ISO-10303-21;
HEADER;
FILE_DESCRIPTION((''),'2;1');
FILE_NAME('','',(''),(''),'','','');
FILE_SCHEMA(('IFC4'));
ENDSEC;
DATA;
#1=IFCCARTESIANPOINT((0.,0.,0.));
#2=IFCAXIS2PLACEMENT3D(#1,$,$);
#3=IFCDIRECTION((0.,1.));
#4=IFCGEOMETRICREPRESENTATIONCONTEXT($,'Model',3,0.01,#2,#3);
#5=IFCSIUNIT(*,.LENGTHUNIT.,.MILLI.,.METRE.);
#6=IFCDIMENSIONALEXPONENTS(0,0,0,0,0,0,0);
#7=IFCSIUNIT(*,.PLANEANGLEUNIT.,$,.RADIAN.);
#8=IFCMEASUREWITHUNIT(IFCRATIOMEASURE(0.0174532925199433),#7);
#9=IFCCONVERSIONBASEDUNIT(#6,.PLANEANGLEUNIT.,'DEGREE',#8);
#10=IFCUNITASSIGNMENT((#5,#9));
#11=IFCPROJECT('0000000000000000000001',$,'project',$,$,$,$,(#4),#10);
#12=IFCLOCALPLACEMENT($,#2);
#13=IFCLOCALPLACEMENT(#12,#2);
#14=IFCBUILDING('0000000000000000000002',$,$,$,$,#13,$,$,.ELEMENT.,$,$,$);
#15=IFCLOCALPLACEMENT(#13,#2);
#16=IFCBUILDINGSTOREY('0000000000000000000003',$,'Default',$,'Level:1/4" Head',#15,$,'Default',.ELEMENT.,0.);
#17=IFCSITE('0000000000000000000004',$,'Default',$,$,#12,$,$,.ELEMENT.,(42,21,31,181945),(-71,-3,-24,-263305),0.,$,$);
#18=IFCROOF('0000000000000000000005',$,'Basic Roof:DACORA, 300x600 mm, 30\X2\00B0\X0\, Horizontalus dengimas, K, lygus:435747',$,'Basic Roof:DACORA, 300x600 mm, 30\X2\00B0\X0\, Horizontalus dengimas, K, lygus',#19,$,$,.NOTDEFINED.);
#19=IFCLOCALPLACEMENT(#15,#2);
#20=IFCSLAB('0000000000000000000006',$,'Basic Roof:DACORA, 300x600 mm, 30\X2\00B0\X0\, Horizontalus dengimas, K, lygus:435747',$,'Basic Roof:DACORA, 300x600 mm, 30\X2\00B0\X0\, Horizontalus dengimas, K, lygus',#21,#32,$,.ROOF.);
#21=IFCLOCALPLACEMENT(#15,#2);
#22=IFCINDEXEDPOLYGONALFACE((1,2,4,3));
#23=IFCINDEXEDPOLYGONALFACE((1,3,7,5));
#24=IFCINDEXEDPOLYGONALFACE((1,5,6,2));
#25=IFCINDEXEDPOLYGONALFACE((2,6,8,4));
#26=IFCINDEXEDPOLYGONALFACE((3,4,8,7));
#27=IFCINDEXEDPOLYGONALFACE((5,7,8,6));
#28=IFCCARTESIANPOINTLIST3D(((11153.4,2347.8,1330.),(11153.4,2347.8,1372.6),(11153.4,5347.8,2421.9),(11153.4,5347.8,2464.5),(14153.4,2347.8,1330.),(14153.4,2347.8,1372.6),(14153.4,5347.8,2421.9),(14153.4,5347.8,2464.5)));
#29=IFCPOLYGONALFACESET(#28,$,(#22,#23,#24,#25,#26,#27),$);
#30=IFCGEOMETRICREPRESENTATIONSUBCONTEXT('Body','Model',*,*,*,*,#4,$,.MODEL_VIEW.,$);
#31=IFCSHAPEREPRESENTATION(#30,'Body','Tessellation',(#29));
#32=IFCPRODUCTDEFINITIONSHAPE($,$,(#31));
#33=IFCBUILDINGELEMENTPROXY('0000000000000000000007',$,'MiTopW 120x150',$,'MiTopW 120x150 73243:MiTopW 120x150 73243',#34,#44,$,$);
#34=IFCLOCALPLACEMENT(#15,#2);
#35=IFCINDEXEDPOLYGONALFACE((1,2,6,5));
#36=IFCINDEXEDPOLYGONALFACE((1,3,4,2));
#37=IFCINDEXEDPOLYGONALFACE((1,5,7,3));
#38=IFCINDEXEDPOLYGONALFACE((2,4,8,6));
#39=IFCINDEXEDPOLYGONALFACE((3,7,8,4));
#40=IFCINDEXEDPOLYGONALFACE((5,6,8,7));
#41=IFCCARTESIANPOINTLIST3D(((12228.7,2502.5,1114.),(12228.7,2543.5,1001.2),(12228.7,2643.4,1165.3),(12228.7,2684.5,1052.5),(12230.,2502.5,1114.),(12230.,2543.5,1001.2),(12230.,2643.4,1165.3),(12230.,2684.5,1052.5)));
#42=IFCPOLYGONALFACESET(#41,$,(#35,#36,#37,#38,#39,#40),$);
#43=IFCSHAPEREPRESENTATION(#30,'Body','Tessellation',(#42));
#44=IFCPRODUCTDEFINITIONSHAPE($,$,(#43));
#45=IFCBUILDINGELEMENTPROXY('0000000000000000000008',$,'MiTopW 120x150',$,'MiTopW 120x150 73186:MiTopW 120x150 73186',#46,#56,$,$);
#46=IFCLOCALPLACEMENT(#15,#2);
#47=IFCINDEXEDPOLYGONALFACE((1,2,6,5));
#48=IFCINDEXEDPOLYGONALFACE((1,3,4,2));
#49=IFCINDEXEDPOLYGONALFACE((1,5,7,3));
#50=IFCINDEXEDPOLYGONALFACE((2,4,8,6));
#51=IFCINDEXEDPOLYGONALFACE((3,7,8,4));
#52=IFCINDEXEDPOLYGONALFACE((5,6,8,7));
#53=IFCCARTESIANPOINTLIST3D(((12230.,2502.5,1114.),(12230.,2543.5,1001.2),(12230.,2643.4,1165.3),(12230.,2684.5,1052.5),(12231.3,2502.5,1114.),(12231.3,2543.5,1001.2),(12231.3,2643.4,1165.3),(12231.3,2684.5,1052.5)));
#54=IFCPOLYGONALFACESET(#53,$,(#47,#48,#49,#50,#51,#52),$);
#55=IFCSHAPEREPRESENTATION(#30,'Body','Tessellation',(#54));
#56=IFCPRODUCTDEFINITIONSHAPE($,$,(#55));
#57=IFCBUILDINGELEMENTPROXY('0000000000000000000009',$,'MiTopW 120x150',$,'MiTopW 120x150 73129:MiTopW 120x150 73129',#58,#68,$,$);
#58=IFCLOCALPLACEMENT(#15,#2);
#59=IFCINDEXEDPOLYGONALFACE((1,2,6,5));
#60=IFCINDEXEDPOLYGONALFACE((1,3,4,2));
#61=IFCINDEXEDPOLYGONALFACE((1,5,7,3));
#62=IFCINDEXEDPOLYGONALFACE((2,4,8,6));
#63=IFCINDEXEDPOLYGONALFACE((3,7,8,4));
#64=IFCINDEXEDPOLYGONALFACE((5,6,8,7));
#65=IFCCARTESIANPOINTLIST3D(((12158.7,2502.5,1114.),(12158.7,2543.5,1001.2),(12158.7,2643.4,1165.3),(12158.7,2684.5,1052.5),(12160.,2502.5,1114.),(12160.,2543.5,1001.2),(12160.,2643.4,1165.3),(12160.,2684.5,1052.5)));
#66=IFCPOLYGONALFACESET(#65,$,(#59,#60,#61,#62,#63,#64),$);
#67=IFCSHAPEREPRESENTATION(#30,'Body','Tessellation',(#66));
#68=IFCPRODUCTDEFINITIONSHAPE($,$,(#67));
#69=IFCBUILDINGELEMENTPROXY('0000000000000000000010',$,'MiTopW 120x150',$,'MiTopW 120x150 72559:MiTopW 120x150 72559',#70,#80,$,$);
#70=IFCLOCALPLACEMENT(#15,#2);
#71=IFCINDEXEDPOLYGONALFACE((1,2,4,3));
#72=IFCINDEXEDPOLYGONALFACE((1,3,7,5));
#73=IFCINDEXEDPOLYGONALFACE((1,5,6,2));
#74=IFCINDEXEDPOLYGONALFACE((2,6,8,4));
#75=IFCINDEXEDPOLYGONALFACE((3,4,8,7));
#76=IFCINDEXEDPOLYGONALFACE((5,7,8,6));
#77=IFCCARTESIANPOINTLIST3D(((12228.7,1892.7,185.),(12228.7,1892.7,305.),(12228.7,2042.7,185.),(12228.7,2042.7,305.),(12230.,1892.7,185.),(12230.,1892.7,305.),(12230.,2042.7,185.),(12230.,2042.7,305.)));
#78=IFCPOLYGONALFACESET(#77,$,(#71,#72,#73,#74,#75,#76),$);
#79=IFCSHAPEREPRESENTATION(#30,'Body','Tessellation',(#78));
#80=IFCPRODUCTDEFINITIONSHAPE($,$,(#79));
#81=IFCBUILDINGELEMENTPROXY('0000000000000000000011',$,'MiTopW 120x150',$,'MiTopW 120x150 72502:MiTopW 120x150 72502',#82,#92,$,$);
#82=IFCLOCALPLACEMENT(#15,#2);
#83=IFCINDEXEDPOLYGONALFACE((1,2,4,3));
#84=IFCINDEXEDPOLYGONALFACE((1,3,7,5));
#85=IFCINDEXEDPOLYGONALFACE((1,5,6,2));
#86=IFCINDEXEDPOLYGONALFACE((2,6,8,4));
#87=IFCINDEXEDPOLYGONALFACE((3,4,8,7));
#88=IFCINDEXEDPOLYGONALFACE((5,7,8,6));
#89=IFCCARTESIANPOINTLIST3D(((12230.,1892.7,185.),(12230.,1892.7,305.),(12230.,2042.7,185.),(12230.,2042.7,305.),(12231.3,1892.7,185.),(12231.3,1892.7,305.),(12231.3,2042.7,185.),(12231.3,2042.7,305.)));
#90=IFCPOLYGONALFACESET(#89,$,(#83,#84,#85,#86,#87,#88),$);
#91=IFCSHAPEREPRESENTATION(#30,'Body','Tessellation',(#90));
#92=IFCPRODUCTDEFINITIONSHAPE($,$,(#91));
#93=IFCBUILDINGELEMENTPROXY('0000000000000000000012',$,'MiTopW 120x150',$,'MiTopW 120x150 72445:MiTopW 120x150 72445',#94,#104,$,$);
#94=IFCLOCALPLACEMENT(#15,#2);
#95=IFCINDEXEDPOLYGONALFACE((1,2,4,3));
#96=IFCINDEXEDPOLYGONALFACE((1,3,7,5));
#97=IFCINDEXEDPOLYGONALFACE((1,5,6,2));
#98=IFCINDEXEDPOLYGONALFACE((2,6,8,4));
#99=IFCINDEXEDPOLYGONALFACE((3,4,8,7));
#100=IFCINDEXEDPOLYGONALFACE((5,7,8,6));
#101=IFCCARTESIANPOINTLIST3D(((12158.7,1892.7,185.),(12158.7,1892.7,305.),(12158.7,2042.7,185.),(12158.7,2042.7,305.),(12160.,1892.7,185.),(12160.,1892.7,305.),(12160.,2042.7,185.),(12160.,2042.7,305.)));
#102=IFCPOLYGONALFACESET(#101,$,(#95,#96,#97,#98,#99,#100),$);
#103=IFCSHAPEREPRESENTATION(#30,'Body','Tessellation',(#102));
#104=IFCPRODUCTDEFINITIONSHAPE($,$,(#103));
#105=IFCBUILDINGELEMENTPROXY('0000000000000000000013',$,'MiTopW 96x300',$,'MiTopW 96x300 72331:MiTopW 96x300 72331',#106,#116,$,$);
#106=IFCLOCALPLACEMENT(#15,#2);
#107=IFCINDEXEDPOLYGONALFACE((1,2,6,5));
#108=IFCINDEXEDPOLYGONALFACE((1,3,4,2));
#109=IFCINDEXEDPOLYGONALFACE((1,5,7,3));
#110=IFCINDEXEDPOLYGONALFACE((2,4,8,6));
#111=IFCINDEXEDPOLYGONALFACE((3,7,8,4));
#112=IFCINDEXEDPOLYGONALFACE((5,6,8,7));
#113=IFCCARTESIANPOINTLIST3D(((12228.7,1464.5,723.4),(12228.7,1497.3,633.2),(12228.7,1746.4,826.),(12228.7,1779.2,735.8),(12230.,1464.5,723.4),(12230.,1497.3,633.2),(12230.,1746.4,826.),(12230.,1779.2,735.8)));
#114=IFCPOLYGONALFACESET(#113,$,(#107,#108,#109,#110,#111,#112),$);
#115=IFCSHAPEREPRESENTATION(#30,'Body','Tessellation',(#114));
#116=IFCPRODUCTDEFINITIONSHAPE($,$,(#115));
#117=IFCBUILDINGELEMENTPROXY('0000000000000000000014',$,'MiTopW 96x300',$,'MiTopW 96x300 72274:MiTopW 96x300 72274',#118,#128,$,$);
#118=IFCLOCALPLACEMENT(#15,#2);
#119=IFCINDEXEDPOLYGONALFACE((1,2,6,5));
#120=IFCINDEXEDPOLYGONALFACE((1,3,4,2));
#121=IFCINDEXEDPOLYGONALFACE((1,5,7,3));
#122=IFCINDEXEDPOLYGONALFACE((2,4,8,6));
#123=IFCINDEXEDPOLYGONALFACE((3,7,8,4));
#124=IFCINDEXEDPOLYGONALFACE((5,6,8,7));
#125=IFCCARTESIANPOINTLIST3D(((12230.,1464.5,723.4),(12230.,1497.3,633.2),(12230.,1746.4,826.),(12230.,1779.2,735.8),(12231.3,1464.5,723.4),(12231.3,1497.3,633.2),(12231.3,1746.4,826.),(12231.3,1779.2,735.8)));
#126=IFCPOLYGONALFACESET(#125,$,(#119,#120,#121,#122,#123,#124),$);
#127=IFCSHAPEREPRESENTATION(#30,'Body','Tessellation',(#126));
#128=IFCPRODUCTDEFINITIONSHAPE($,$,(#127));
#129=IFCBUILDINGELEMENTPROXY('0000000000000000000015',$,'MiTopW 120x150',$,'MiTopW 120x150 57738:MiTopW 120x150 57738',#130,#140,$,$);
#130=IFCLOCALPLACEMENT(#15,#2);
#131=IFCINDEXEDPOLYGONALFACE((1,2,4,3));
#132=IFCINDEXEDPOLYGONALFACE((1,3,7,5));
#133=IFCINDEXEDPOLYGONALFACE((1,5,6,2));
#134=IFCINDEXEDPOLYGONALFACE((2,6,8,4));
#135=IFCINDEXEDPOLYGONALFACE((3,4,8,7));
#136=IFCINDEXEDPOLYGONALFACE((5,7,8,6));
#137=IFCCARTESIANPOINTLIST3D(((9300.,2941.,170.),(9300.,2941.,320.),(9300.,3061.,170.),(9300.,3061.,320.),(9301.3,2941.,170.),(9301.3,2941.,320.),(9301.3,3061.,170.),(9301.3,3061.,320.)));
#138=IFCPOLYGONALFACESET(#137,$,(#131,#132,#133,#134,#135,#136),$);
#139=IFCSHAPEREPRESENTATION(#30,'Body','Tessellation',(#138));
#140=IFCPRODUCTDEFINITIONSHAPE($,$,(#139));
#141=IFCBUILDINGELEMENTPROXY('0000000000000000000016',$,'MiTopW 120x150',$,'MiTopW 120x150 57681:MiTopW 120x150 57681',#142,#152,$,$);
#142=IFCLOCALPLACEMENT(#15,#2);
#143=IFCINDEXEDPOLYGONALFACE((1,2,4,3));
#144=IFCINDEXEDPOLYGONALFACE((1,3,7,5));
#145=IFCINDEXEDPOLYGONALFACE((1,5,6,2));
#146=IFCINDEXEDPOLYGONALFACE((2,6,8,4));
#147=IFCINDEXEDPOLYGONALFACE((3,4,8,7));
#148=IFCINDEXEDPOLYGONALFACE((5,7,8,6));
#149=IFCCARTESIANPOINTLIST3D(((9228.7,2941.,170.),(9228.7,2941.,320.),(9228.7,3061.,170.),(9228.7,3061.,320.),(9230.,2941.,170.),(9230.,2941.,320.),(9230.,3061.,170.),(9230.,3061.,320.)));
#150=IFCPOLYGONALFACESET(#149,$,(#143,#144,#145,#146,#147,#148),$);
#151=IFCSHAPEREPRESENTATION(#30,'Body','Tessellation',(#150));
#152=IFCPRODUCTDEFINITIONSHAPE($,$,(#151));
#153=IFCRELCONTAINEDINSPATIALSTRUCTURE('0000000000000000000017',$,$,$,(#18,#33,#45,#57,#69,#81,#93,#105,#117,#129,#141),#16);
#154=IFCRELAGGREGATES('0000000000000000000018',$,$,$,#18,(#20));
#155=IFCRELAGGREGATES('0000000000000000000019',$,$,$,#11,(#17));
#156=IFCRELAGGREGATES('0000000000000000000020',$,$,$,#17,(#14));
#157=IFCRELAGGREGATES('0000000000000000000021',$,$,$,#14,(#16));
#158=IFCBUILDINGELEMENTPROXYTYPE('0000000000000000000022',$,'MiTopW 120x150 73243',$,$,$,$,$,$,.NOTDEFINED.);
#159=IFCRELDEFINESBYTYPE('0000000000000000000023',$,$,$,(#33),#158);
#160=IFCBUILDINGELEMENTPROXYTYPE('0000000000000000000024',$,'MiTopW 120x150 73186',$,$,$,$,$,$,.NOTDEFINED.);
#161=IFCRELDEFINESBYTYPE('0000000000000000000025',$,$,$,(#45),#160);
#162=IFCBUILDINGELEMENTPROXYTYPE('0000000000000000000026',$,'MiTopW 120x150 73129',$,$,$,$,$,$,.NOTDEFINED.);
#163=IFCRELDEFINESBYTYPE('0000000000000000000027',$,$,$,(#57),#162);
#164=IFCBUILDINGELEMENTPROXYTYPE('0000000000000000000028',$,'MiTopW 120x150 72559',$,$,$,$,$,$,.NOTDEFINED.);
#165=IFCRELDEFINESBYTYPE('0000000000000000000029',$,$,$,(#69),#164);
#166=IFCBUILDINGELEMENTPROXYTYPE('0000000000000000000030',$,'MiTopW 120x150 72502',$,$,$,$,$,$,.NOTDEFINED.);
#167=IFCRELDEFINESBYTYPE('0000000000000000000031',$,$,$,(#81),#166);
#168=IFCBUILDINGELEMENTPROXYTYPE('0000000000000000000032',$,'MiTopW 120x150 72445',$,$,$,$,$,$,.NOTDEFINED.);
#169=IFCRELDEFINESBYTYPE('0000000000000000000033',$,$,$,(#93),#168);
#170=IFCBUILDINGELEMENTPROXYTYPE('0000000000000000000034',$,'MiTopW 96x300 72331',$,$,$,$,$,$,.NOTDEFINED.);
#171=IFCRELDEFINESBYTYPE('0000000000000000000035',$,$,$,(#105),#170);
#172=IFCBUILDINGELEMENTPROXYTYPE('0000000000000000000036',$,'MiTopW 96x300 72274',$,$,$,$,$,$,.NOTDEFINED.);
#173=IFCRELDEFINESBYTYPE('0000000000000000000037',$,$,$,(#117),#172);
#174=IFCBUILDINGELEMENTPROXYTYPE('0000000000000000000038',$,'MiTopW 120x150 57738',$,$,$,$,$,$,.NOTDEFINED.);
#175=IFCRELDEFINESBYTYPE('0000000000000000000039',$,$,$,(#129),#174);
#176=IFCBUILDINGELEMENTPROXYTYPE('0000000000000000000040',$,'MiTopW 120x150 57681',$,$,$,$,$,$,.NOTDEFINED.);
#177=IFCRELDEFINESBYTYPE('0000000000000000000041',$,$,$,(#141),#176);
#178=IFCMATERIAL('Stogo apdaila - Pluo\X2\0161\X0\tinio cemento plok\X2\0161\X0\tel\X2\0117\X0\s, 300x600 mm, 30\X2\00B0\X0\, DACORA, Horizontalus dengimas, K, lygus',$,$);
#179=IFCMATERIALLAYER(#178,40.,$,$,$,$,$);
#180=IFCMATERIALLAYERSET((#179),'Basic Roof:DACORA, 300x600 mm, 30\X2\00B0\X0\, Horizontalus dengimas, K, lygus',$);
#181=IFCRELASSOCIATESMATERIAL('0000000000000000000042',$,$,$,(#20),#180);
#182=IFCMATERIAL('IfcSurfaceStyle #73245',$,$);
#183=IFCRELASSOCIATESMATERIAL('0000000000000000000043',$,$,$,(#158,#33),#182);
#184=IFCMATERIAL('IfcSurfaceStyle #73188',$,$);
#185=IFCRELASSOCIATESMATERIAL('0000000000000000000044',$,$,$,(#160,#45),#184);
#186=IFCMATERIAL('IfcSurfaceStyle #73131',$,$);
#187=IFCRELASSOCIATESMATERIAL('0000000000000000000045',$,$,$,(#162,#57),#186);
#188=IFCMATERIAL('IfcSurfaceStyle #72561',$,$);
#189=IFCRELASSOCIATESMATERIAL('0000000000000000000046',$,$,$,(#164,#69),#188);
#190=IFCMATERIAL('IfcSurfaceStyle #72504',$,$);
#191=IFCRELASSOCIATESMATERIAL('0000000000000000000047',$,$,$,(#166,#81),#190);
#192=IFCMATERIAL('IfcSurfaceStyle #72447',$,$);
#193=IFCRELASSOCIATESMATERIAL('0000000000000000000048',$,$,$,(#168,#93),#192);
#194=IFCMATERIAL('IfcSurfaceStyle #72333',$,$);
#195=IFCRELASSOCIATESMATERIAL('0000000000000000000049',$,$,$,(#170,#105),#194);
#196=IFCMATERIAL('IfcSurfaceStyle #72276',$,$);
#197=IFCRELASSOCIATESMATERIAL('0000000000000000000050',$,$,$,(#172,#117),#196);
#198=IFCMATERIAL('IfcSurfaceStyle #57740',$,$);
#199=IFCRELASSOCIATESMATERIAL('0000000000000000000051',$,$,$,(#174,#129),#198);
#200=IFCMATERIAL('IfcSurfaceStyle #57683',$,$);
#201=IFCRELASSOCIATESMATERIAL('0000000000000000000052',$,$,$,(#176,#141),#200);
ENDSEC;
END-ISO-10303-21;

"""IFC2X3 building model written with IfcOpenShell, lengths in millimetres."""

from ifc_helpers import new_model, entity, si_unit, converted_unit, direction, frame, frame_2d, origin, origin_2d_with_axis, place, context, subcontext, project, spatial, polyline, rectangle, outline, extrude, source, transform, mapped, material, layer, layer_set, type_object, type_shapes, element, aggregate, save


model = new_model("IFC2X3")

# Units and contexts
model_context = context("Model", 3, precision=0.01, world=origin(), true_north=direction((0.0, 1.0)))
body_context = subcontext(model_context, "Body", "Model", "MODEL_VIEW")
ifc_project = project(units=[si_unit("LENGTHUNIT", "METRE", prefix="MILLI"), converted_unit("PLANEANGLEUNIT", "DEGREE", entity("IfcRatioMeasure", 0.0174532925199433), si_unit("PLANEANGLEUNIT", "RADIAN"), dimensions=[0, 0, 0, 0, 0, 0, 0])], contexts=[model_context])

# Site, building, storey
site_placement = place(None, origin())
site = spatial("IfcSite", under=ifc_project, at=site_placement, Name="Default", CompositionType="ELEMENT", RefLatitude=(42, 21, 31, 181945), RefLongitude=(-71, -3, -24, -263305), RefElevation=0.0)
building_placement = place(site_placement, origin())
building = spatial("IfcBuilding", under=site, at=building_placement, CompositionType="ELEMENT")
storey_placement = place(building_placement, origin())
storey = spatial("IfcBuildingStorey", under=building, at=storey_placement, Name="Default", ObjectType="Level:1/4\" Head", LongName="Default", CompositionType="ELEMENT", Elevation=0.0)

# Roof, slab
roof_placement = place(storey_placement, frame((11153.4, 2347.8, 1330.0)))
roof = element("IfcRoof", 1, at=roof_placement, inside=storey, Name="Basic Roof:DACORA, 300x600 mm, 30°, Horizontalus dengimas, K, lygus:435747", ObjectType="Basic Roof:DACORA, 300x600 mm, 30°, Horizontalus dengimas, K, lygus", ShapeType="NOTDEFINED")
ifc_material_1 = material(Name="Stogo apdaila - Pluoštinio cemento plokštelės, 300x600 mm, 30°, DACORA, Horizontalus dengimas, K, lygus")
ifc_layer = layer(ifc_material_1, 40.0)
ifc_layer_set = layer_set([ifc_layer], Name="Basic Roof:DACORA, 300x600 mm, 30°, Horizontalus dengimas, K, lygus")
slab_placement = place(roof_placement, origin())
slab = element("IfcSlab", 2, at=slab_placement, material=ifc_layer_set, Name="Basic Roof:DACORA, 300x600 mm, 30°, Horizontalus dengimas, K, lygus:435747", ObjectType="Basic Roof:DACORA, 300x600 mm, 30°, Horizontalus dengimas, K, lygus", PredefinedType="ROOF", context=body_context, shape_type="SweptSolid", body=[
    extrude(rectangle(XDim=3192.5, YDim=3000.0, at=frame_2d((0.0, 0.0), x_axis=(0.0, -1.0))), frame((1500.0, 1500.0, 546.0), z_axis=(0.0, -0.34202, 0.939693), x_axis=(1.0, 0.0, 0.0)), (0.0, 0.34202, 0.939693), 42.6),
])
aggregate(roof, [slab])

# Building element proxies
ifc_material_2 = material(Name="IfcSurfaceStyle #73245")
building_element_proxy_type_1 = type_object("IfcBuildingElementProxyType", Name="MiTopW 120x150 73243", PredefinedType="NOTDEFINED", material=ifc_material_2)
shared_shape_1 = source(origin(), body_context, "Body", "SweptSolid", [
    extrude(outline(polyline([(-75.0, -60.0), (75.0, -60.0), (75.0, 60.0), (-75.0, 60.0), (-75.0, -60.0)])), frame((75.0, 60.0, 0.0), z_axis=(0.0, 0.0, 1.0), x_axis=(-1.0, 0.0, 0.0)), (0.0, 0.0, 1.0), 1.3),
])
type_shapes(building_element_proxy_type_1, [shared_shape_1])
proxy_1_placement = place(building_placement, frame((12230.0, 2502.5, 1114.0), z_axis=(-1.0, 0.0, 0.0), x_axis=(0.0, 0.939693, 0.34202)))
element("IfcBuildingElementProxy", 3, at=proxy_1_placement, inside=storey, type_object=building_element_proxy_type_1, material=ifc_material_2, Name="MiTopW 120x150", ObjectType="MiTopW 120x150 73243:MiTopW 120x150 73243", context=body_context, shape_type="MappedRepresentation", body=[
    mapped(shared_shape_1, transform((0.0, 0.0, 0.0), scale=1.0)),
])
ifc_material_3 = material(Name="IfcSurfaceStyle #73188")
building_element_proxy_type_2 = type_object("IfcBuildingElementProxyType", Name="MiTopW 120x150 73186", PredefinedType="NOTDEFINED", material=ifc_material_3)
shared_shape_2 = source(origin(), body_context, "Body", "SweptSolid", [
    extrude(outline(polyline([(-75.0, -60.0), (75.0, -60.0), (75.0, 60.0), (-75.0, 60.0), (-75.0, -60.0)])), frame((75.0, 60.0, 0.0), z_axis=(0.0, 0.0, 1.0), x_axis=(-1.0, 0.0, 0.0)), (0.0, 0.0, 1.0), 1.3),
])
type_shapes(building_element_proxy_type_2, [shared_shape_2])
proxy_2_placement = place(building_placement, frame((12231.3, 2502.5, 1114.0), z_axis=(-1.0, 0.0, 0.0), x_axis=(0.0, 0.939693, 0.34202)))
element("IfcBuildingElementProxy", 4, at=proxy_2_placement, inside=storey, type_object=building_element_proxy_type_2, material=ifc_material_3, Name="MiTopW 120x150", ObjectType="MiTopW 120x150 73186:MiTopW 120x150 73186", context=body_context, shape_type="MappedRepresentation", body=[
    mapped(shared_shape_2, transform((0.0, 0.0, 0.0), scale=1.0)),
])
ifc_material_4 = material(Name="IfcSurfaceStyle #73131")
building_element_proxy_type_3 = type_object("IfcBuildingElementProxyType", Name="MiTopW 120x150 73129", PredefinedType="NOTDEFINED", material=ifc_material_4)
shared_shape_3 = source(origin(), body_context, "Body", "SweptSolid", [
    extrude(outline(polyline([(-75.0, -60.0), (75.0, -60.0), (75.0, 60.0), (-75.0, 60.0), (-75.0, -60.0)])), frame((75.0, 60.0, 0.0), z_axis=(0.0, 0.0, 1.0), x_axis=(-1.0, 0.0, 0.0)), (0.0, 0.0, 1.0), 1.3),
])
type_shapes(building_element_proxy_type_3, [shared_shape_3])
proxy_3_placement = place(building_placement, frame((12160.0, 2502.5, 1114.0), z_axis=(-1.0, 0.0, 0.0), x_axis=(0.0, 0.939693, 0.34202)))
element("IfcBuildingElementProxy", 5, at=proxy_3_placement, inside=storey, type_object=building_element_proxy_type_3, material=ifc_material_4, Name="MiTopW 120x150", ObjectType="MiTopW 120x150 73129:MiTopW 120x150 73129", context=body_context, shape_type="MappedRepresentation", body=[
    mapped(shared_shape_3, transform((0.0, 0.0, 0.0), scale=1.0)),
])
ifc_material_5 = material(Name="IfcSurfaceStyle #72561")
building_element_proxy_type_4 = type_object("IfcBuildingElementProxyType", Name="MiTopW 120x150 72559", PredefinedType="NOTDEFINED", material=ifc_material_5)
shared_shape_4 = source(origin(), body_context, "Body", "SweptSolid", [
    extrude(rectangle(XDim=150.0, YDim=120.0, at=origin_2d_with_axis()), frame((75.0, 60.0, 0.0), z_axis=(0.0, 0.0, 1.0), x_axis=(-1.0, 0.0, 0.0)), (0.0, 0.0, 1.0), 1.3),
])
type_shapes(building_element_proxy_type_4, [shared_shape_4])
proxy_4_placement = place(building_placement, frame((12230.0, 1892.7, 305.0), z_axis=(-1.0, 0.0, 0.0), x_axis=(0.0, 1.0, 0.0)))
element("IfcBuildingElementProxy", 6, at=proxy_4_placement, inside=storey, type_object=building_element_proxy_type_4, material=ifc_material_5, Name="MiTopW 120x150", ObjectType="MiTopW 120x150 72559:MiTopW 120x150 72559", context=body_context, shape_type="MappedRepresentation", body=[
    mapped(shared_shape_4, transform((0.0, 0.0, 0.0), scale=1.0)),
])
ifc_material_6 = material(Name="IfcSurfaceStyle #72504")
building_element_proxy_type_5 = type_object("IfcBuildingElementProxyType", Name="MiTopW 120x150 72502", PredefinedType="NOTDEFINED", material=ifc_material_6)
shared_shape_5 = source(origin(), body_context, "Body", "SweptSolid", [
    extrude(rectangle(XDim=150.0, YDim=120.0, at=origin_2d_with_axis()), frame((75.0, 60.0, 0.0), z_axis=(0.0, 0.0, 1.0), x_axis=(-1.0, 0.0, 0.0)), (0.0, 0.0, 1.0), 1.3),
])
type_shapes(building_element_proxy_type_5, [shared_shape_5])
proxy_5_placement = place(building_placement, frame((12231.3, 1892.7, 305.0), z_axis=(-1.0, 0.0, 0.0), x_axis=(0.0, 1.0, 0.0)))
element("IfcBuildingElementProxy", 7, at=proxy_5_placement, inside=storey, type_object=building_element_proxy_type_5, material=ifc_material_6, Name="MiTopW 120x150", ObjectType="MiTopW 120x150 72502:MiTopW 120x150 72502", context=body_context, shape_type="MappedRepresentation", body=[
    mapped(shared_shape_5, transform((0.0, 0.0, 0.0), scale=1.0)),
])
ifc_material_7 = material(Name="IfcSurfaceStyle #72447")
building_element_proxy_type_6 = type_object("IfcBuildingElementProxyType", Name="MiTopW 120x150 72445", PredefinedType="NOTDEFINED", material=ifc_material_7)
shared_shape_6 = source(origin(), body_context, "Body", "SweptSolid", [
    extrude(rectangle(XDim=150.0, YDim=120.0, at=origin_2d_with_axis()), frame((75.0, 60.0, 0.0), z_axis=(0.0, 0.0, 1.0), x_axis=(-1.0, 0.0, 0.0)), (0.0, 0.0, 1.0), 1.3),
])
type_shapes(building_element_proxy_type_6, [shared_shape_6])
proxy_6_placement = place(building_placement, frame((12160.0, 1892.7, 305.0), z_axis=(-1.0, 0.0, 0.0), x_axis=(0.0, 1.0, 0.0)))
element("IfcBuildingElementProxy", 8, at=proxy_6_placement, inside=storey, type_object=building_element_proxy_type_6, material=ifc_material_7, Name="MiTopW 120x150", ObjectType="MiTopW 120x150 72445:MiTopW 120x150 72445", context=body_context, shape_type="MappedRepresentation", body=[
    mapped(shared_shape_6, transform((0.0, 0.0, 0.0), scale=1.0)),
])
ifc_material_8 = material(Name="IfcSurfaceStyle #72333")
building_element_proxy_type_7 = type_object("IfcBuildingElementProxyType", Name="MiTopW 96x300 72331", PredefinedType="NOTDEFINED", material=ifc_material_8)
shared_shape_7 = source(origin(), body_context, "Body", "SweptSolid", [
    extrude(outline(polyline([(-150.0, -48.0), (150.0, -48.0), (150.0, 48.0), (-150.0, 48.0), (-150.0, -48.0)])), frame((150.0, 48.0, 0.0), z_axis=(0.0, 0.0, 1.0), x_axis=(-1.0, 0.0, 0.0)), (0.0, 0.0, 1.0), 1.3),
])
type_shapes(building_element_proxy_type_7, [shared_shape_7])
proxy_7_placement = place(building_placement, frame((12230.0, 1464.5, 723.4), z_axis=(-1.0, 0.0, 0.0), x_axis=(0.0, 0.939693, 0.34202)))
element("IfcBuildingElementProxy", 9, at=proxy_7_placement, inside=storey, type_object=building_element_proxy_type_7, material=ifc_material_8, Name="MiTopW 96x300", ObjectType="MiTopW 96x300 72331:MiTopW 96x300 72331", context=body_context, shape_type="MappedRepresentation", body=[
    mapped(shared_shape_7, transform((0.0, 0.0, 0.0), scale=1.0)),
])
ifc_material_9 = material(Name="IfcSurfaceStyle #72276")
building_element_proxy_type_8 = type_object("IfcBuildingElementProxyType", Name="MiTopW 96x300 72274", PredefinedType="NOTDEFINED", material=ifc_material_9)
shared_shape_8 = source(origin(), body_context, "Body", "SweptSolid", [
    extrude(outline(polyline([(-150.0, -48.0), (150.0, -48.0), (150.0, 48.0), (-150.0, 48.0), (-150.0, -48.0)])), frame((150.0, 48.0, 0.0), z_axis=(0.0, 0.0, 1.0), x_axis=(-1.0, 0.0, 0.0)), (0.0, 0.0, 1.0), 1.3),
])
type_shapes(building_element_proxy_type_8, [shared_shape_8])
proxy_8_placement = place(building_placement, frame((12231.3, 1464.5, 723.4), z_axis=(-1.0, 0.0, 0.0), x_axis=(0.0, 0.939693, 0.34202)))
element("IfcBuildingElementProxy", 10, at=proxy_8_placement, inside=storey, type_object=building_element_proxy_type_8, material=ifc_material_9, Name="MiTopW 96x300", ObjectType="MiTopW 96x300 72274:MiTopW 96x300 72274", context=body_context, shape_type="MappedRepresentation", body=[
    mapped(shared_shape_8, transform((0.0, 0.0, 0.0), scale=1.0)),
])
ifc_material_10 = material(Name="IfcSurfaceStyle #57740")
building_element_proxy_type_9 = type_object("IfcBuildingElementProxyType", Name="MiTopW 120x150 57738", PredefinedType="NOTDEFINED", material=ifc_material_10)
shared_shape_9 = source(origin(), body_context, "Body", "SweptSolid", [
    extrude(rectangle(XDim=150.0, YDim=120.0, at=frame_2d((0.0, 0.0), x_axis=(1.0, 0.0))), frame((75.0, 60.0, 0.0), z_axis=(0.0, 0.0, 1.0), x_axis=(-1.0, 0.0, 0.0)), (0.0, 0.0, 1.0), 1.3),
])
type_shapes(building_element_proxy_type_9, [shared_shape_9])
proxy_9_placement = place(building_placement, frame((9301.3, 2941.0, 170.0), z_axis=(-1.0, 0.0, 0.0), x_axis=(0.0, 0.0, 1.0)))
element("IfcBuildingElementProxy", 11, at=proxy_9_placement, inside=storey, type_object=building_element_proxy_type_9, material=ifc_material_10, Name="MiTopW 120x150", ObjectType="MiTopW 120x150 57738:MiTopW 120x150 57738", context=body_context, shape_type="MappedRepresentation", body=[
    mapped(shared_shape_9, transform((0.0, 0.0, 0.0), scale=1.0)),
])
ifc_material_11 = material(Name="IfcSurfaceStyle #57683")
building_element_proxy_type_10 = type_object("IfcBuildingElementProxyType", Name="MiTopW 120x150 57681", PredefinedType="NOTDEFINED", material=ifc_material_11)
shared_shape_10 = source(origin(), body_context, "Body", "SweptSolid", [
    extrude(rectangle(XDim=150.0, YDim=120.0, at=frame_2d((0.0, 0.0), x_axis=(1.0, 0.0))), frame((75.0, 60.0, 0.0), z_axis=(0.0, 0.0, 1.0), x_axis=(-1.0, 0.0, 0.0)), (0.0, 0.0, 1.0), 1.3),
])
type_shapes(building_element_proxy_type_10, [shared_shape_10])
proxy_10_placement = place(building_placement, frame((9230.0, 2941.0, 170.0), z_axis=(-1.0, 0.0, 0.0), x_axis=(0.0, 0.0, 1.0)))
element("IfcBuildingElementProxy", 12, at=proxy_10_placement, inside=storey, type_object=building_element_proxy_type_10, material=ifc_material_11, Name="MiTopW 120x150", ObjectType="MiTopW 120x150 57681:MiTopW 120x150 57681", context=body_context, shape_type="MappedRepresentation", body=[
    mapped(shared_shape_10, transform((0.0, 0.0, 0.0), scale=1.0)),
])

save(model, "model.ifc")
